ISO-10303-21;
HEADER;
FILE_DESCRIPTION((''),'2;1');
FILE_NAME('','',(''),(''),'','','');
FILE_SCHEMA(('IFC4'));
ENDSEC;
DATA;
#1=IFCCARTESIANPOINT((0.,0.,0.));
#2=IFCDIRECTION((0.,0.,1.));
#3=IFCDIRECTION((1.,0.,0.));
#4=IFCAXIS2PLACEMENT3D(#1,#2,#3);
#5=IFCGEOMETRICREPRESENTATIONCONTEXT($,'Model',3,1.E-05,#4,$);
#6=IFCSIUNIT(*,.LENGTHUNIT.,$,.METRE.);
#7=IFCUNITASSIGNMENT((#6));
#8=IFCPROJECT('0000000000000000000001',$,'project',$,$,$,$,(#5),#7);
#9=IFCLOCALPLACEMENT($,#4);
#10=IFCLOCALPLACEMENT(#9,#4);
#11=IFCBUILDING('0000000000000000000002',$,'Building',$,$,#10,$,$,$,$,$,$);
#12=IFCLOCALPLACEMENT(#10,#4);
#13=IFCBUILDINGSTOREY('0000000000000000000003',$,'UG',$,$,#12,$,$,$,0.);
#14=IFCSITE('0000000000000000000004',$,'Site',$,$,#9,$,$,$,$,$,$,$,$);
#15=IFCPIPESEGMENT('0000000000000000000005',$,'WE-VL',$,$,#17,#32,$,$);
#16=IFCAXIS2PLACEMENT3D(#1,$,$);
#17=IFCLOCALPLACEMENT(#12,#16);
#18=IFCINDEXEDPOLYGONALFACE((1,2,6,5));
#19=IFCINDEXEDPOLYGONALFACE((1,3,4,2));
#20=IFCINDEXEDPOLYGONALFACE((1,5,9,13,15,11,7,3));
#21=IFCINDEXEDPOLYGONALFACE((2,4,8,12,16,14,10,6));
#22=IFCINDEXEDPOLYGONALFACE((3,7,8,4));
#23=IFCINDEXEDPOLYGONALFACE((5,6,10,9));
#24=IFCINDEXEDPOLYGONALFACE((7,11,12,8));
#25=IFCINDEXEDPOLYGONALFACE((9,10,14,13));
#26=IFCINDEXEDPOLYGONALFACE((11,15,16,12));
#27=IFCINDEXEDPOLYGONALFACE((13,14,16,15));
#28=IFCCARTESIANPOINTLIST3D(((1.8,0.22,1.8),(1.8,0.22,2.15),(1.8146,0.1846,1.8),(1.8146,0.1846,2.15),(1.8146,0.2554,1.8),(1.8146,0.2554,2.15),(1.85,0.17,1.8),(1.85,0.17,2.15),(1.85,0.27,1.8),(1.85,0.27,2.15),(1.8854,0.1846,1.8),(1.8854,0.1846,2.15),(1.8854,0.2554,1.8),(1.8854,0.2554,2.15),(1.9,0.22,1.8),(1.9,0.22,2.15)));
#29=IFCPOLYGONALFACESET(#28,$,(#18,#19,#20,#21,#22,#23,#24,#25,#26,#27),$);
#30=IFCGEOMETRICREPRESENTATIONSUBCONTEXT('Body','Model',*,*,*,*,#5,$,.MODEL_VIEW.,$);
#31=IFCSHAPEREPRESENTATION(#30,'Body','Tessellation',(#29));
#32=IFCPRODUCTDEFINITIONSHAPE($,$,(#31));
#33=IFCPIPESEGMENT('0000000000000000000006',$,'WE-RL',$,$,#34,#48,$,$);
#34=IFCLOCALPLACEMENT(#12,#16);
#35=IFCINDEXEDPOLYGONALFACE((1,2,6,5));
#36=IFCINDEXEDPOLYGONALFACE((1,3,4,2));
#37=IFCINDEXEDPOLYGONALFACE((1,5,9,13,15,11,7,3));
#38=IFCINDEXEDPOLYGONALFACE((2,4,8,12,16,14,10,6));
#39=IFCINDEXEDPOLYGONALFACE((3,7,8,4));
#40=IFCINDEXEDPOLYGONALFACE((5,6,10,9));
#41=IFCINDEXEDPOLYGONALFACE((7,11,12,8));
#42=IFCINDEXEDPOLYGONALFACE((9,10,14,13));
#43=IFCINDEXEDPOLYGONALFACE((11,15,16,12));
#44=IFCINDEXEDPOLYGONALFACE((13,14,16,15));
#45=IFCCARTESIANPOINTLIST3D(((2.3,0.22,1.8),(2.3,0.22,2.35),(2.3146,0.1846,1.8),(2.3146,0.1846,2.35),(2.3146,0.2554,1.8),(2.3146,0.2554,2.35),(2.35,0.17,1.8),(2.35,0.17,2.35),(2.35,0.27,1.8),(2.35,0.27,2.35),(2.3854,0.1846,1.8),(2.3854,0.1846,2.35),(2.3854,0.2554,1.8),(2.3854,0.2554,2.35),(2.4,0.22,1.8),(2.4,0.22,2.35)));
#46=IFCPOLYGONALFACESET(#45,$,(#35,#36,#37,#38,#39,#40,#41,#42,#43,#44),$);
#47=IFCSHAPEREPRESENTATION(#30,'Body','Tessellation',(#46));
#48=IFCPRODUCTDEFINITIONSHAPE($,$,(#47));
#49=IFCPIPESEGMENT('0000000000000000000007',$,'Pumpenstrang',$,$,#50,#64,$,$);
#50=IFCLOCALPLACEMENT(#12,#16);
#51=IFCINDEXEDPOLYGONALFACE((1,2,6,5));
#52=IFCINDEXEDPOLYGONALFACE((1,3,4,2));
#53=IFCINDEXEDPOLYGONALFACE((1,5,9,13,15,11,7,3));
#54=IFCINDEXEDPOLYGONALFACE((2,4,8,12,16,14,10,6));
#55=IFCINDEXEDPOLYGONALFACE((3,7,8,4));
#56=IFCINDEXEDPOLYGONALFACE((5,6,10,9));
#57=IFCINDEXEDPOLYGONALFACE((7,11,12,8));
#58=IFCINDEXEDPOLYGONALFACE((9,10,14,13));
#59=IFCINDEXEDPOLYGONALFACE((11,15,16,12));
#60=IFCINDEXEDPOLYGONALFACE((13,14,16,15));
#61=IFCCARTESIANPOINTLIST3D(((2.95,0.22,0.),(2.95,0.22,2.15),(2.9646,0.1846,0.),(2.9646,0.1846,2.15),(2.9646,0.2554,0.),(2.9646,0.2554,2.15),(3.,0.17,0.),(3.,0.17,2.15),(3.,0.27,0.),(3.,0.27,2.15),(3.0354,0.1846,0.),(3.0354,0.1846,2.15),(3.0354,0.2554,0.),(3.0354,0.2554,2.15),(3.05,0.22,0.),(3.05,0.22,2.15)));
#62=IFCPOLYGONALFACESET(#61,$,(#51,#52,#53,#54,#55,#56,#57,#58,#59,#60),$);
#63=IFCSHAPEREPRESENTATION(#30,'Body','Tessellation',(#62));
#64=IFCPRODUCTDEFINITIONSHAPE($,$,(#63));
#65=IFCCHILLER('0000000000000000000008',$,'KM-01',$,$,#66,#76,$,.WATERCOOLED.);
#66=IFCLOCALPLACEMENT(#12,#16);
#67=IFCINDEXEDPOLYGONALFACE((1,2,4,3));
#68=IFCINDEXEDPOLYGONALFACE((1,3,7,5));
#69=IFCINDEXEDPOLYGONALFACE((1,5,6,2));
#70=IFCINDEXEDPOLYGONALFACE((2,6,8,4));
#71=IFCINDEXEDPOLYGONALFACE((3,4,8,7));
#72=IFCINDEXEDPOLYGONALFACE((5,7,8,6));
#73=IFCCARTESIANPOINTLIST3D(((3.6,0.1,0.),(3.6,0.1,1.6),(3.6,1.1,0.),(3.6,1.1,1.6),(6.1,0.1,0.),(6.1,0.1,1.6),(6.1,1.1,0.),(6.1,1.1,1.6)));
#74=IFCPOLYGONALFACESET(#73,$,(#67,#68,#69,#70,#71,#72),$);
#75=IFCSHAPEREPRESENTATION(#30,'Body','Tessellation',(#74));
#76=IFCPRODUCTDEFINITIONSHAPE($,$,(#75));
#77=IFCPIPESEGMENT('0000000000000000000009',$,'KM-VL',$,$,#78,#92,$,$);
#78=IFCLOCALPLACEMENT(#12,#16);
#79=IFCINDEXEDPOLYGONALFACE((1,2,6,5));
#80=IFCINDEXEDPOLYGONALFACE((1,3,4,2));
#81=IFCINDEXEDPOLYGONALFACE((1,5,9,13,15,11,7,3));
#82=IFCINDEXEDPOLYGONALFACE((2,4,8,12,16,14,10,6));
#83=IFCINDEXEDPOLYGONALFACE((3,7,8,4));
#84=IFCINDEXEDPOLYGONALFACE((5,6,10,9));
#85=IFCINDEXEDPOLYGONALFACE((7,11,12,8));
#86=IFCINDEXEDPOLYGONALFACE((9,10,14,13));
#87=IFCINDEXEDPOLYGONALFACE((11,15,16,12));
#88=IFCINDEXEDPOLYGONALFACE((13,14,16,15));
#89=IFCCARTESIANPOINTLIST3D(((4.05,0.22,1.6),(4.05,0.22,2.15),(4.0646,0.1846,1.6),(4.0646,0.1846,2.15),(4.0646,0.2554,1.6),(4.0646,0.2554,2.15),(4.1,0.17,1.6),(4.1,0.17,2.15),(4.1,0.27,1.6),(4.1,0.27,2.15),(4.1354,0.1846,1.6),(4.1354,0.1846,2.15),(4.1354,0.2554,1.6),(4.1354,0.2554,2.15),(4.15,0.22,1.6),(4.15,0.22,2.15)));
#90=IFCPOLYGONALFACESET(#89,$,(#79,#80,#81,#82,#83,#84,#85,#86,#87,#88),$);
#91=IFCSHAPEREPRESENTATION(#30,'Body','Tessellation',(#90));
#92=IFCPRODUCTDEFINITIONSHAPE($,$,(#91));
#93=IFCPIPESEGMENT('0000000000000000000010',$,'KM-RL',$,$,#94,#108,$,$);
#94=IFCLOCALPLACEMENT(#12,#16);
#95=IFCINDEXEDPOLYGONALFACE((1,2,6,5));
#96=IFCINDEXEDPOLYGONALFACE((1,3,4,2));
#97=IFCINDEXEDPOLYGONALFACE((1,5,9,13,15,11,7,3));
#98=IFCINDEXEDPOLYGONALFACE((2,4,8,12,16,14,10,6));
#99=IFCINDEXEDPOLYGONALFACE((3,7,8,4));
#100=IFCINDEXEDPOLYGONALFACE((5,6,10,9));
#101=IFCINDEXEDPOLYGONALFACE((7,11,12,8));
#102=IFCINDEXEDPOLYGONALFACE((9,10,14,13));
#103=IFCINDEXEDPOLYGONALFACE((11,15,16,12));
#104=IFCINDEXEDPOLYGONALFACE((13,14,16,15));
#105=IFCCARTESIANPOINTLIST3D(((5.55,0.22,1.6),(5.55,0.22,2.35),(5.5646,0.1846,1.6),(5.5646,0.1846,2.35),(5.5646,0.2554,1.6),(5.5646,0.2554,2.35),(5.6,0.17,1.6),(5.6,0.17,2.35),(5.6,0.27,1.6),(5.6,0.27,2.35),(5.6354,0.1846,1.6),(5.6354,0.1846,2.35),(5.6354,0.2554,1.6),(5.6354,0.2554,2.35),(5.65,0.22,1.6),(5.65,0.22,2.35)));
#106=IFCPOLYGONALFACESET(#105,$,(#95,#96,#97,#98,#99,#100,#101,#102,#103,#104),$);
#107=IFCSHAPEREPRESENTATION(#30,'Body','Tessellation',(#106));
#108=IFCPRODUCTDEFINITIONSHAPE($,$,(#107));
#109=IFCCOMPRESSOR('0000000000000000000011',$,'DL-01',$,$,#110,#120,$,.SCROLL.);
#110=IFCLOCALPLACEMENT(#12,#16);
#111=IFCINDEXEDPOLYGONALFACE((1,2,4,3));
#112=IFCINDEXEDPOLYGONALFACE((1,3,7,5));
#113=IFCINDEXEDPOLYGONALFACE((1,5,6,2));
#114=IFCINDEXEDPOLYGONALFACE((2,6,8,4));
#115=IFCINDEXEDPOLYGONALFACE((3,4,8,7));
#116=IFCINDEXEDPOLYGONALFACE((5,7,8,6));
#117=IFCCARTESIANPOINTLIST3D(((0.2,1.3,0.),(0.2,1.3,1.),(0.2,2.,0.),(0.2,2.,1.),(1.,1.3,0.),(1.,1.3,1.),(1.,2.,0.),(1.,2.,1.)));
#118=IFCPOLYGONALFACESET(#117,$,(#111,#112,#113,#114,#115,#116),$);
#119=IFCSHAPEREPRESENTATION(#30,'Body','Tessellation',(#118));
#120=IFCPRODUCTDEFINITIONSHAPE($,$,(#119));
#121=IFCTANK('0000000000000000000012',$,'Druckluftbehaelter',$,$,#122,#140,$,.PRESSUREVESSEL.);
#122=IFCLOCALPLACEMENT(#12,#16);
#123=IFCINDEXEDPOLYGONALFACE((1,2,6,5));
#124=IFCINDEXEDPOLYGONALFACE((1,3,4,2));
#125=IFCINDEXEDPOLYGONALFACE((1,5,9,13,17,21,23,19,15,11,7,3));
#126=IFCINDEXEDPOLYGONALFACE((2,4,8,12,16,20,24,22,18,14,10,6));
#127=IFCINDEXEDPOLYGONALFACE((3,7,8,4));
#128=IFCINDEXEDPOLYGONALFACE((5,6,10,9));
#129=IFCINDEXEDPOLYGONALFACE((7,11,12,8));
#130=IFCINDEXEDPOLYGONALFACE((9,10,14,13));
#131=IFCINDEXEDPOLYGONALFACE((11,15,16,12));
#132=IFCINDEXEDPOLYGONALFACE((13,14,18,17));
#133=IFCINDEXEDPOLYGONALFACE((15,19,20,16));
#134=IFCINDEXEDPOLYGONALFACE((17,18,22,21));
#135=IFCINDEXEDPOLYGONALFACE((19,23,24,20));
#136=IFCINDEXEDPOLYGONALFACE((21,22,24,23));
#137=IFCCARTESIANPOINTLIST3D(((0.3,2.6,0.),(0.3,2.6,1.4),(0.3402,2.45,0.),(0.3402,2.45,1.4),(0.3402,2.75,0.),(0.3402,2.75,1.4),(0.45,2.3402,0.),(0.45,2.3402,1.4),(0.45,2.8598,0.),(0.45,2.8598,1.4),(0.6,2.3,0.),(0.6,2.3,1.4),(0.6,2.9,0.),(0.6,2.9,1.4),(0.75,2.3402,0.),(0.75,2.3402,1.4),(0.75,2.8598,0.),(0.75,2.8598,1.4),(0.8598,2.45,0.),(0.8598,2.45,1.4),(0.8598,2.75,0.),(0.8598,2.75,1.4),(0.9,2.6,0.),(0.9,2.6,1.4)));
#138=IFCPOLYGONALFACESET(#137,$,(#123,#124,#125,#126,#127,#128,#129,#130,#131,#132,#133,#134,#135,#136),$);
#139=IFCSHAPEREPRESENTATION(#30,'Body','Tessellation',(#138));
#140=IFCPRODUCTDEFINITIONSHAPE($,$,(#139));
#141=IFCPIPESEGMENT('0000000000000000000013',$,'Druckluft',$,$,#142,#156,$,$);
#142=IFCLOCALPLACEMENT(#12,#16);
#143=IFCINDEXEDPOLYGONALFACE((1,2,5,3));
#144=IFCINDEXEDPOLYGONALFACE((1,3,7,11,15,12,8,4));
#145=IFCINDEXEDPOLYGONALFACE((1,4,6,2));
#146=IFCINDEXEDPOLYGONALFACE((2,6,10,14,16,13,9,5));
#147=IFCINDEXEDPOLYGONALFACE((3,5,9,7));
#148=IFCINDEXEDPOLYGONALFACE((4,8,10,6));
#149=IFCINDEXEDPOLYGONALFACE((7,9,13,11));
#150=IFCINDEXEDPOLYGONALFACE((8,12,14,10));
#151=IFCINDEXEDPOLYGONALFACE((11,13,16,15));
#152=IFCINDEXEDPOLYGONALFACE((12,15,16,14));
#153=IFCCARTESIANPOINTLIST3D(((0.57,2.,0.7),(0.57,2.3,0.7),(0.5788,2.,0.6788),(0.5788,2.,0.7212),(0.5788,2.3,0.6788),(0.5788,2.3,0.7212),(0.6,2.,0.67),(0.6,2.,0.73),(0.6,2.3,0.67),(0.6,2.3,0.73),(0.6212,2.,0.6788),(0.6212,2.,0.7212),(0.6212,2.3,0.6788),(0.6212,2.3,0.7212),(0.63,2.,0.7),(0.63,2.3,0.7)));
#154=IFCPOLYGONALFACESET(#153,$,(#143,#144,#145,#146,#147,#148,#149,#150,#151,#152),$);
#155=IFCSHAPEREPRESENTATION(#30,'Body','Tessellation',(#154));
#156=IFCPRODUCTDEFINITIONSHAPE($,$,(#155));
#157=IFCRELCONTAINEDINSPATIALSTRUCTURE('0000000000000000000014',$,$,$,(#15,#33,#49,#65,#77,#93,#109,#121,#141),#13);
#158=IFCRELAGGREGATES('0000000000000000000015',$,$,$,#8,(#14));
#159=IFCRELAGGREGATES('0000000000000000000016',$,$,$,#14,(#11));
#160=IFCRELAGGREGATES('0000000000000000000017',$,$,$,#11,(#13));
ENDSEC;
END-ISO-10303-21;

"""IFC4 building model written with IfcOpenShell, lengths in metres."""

from ifc_helpers import new_model, si_unit, frame, origin_with_axes, place, context, subcontext, project, spatial, polyline, outline, extrude, element, save


model = new_model("IFC4")

# Units and contexts
model_context = context("Model", 3, precision=1e-05, world=origin_with_axes())
body_context = subcontext(model_context, "Body", "Model", "MODEL_VIEW")
ifc_project = project(units=[si_unit("LENGTHUNIT", "METRE")], contexts=[model_context])

# Site, building, storey
site_placement = place(None, origin_with_axes())
site = spatial("IfcSite", under=ifc_project, at=site_placement, Name="Site")
building_placement = place(site_placement, origin_with_axes())
building = spatial("IfcBuilding", under=site, at=building_placement, Name="Building")
storey_placement = place(building_placement, origin_with_axes())
storey = spatial("IfcBuildingStorey", under=building, at=storey_placement, Name="UG", Elevation=0.0)

# Pipe segments
pipe_segment_1_placement = place(storey_placement, origin_with_axes())
element("IfcPipeSegment", 1, at=pipe_segment_1_placement, inside=storey, Name="WE-VL", context=body_context, shape_type="SweptSolid", body=[
    extrude(outline(polyline([(0.05, 0.0, 0.0), (0.0354, 0.0354, 0.0), (0.0, 0.05, 0.0), (-0.0354, 0.0354, 0.0), (-0.05, 0.0, 0.0), (-0.0354, -0.0354, 0.0), (0.0, -0.05, 0.0), (0.0354, -0.0354, 0.0), (0.05, 0.0, 0.0)])), frame((1.85, 0.22, 1.8), z_axis=(0.0, 0.0, 1.0), x_axis=(1.0, 0.0, 0.0)), (0.0, 0.0, 1.0), 0.35),
])
pipe_segment_2_placement = place(storey_placement, origin_with_axes())
element("IfcPipeSegment", 2, at=pipe_segment_2_placement, inside=storey, Name="WE-RL", context=body_context, shape_type="SweptSolid", body=[
    extrude(outline(polyline([(0.05, 0.0, 0.0), (0.0354, 0.0354, 0.0), (0.0, 0.05, 0.0), (-0.0354, 0.0354, 0.0), (-0.05, 0.0, 0.0), (-0.0354, -0.0354, 0.0), (0.0, -0.05, 0.0), (0.0354, -0.0354, 0.0), (0.05, 0.0, 0.0)])), frame((2.35, 0.22, 1.8), z_axis=(0.0, 0.0, 1.0), x_axis=(1.0, 0.0, 0.0)), (0.0, 0.0, 1.0), 0.55),
])
pipe_segment_3_placement = place(storey_placement, origin_with_axes())
element("IfcPipeSegment", 3, at=pipe_segment_3_placement, inside=storey, Name="Pumpenstrang", context=body_context, shape_type="SweptSolid", body=[
    extrude(outline(polyline([(0.05, 0.0, 0.0), (0.0354, 0.0354, 0.0), (0.0, 0.05, 0.0), (-0.0354, 0.0354, 0.0), (-0.05, 0.0, 0.0), (-0.0354, -0.0354, 0.0), (0.0, -0.05, 0.0), (0.0354, -0.0354, 0.0), (0.05, 0.0, 0.0)])), frame((3.0, 0.22, 0.0), z_axis=(0.0, 0.0, 1.0), x_axis=(1.0, 0.0, 0.0)), (0.0, 0.0, 1.0), 2.15),
])

# Chiller
chiller_placement = place(storey_placement, origin_with_axes())
element("IfcChiller", 4, at=chiller_placement, inside=storey, Name="KM-01", PredefinedType="WATERCOOLED", context=body_context, shape_type="SweptSolid", body=[
    extrude(outline(polyline([(3.6, 0.1, 0.0), (6.1, 0.1, 0.0), (6.1, 1.1, 0.0), (3.6, 1.1, 0.0), (3.6, 0.1, 0.0)])), origin_with_axes(), (0.0, 0.0, 1.0), 1.6),
])

# Pipe segments
pipe_segment_4_placement = place(storey_placement, origin_with_axes())
element("IfcPipeSegment", 5, at=pipe_segment_4_placement, inside=storey, Name="KM-VL", context=body_context, shape_type="SweptSolid", body=[
    extrude(outline(polyline([(0.05, 0.0, 0.0), (0.0354, 0.0354, 0.0), (0.0, 0.05, 0.0), (-0.0354, 0.0354, 0.0), (-0.05, 0.0, 0.0), (-0.0354, -0.0354, 0.0), (0.0, -0.05, 0.0), (0.0354, -0.0354, 0.0), (0.05, 0.0, 0.0)])), frame((4.1, 0.22, 1.6), z_axis=(0.0, 0.0, 1.0), x_axis=(1.0, 0.0, 0.0)), (0.0, 0.0, 1.0), 0.55),
])
pipe_segment_5_placement = place(storey_placement, origin_with_axes())
element("IfcPipeSegment", 6, at=pipe_segment_5_placement, inside=storey, Name="KM-RL", context=body_context, shape_type="SweptSolid", body=[
    extrude(outline(polyline([(0.05, 0.0, 0.0), (0.0354, 0.0354, 0.0), (0.0, 0.05, 0.0), (-0.0354, 0.0354, 0.0), (-0.05, 0.0, 0.0), (-0.0354, -0.0354, 0.0), (0.0, -0.05, 0.0), (0.0354, -0.0354, 0.0), (0.05, 0.0, 0.0)])), frame((5.6, 0.22, 1.6), z_axis=(0.0, 0.0, 1.0), x_axis=(1.0, 0.0, 0.0)), (0.0, 0.0, 1.0), 0.75),
])

# Compressor
compressor_placement = place(storey_placement, origin_with_axes())
element("IfcCompressor", 7, at=compressor_placement, inside=storey, Name="DL-01", PredefinedType="SCROLL", context=body_context, shape_type="SweptSolid", body=[
    extrude(outline(polyline([(0.2, 1.3, 0.0), (1.0, 1.3, 0.0), (1.0, 2.0, 0.0), (0.2, 2.0, 0.0), (0.2, 1.3, 0.0)])), origin_with_axes(), (0.0, 0.0, 1.0), 1.0),
])

# Tank
tank_1_placement = place(storey_placement, origin_with_axes())
element("IfcTank", 8, at=tank_1_placement, inside=storey, Name="Druckluftbehaelter", PredefinedType="PRESSUREVESSEL", context=body_context, shape_type="SweptSolid", body=[
    extrude(outline(polyline([(0.3, 0.0, 0.0), (0.2598, 0.15, 0.0), (0.15, 0.2598, 0.0), (0.0, 0.3, 0.0), (-0.15, 0.2598, 0.0), (-0.2598, 0.15, 0.0), (-0.3, 0.0, 0.0), (-0.2598, -0.15, 0.0), (-0.15, -0.2598, 0.0), (0.0, -0.3, 0.0), (0.15, -0.2598, 0.0), (0.2598, -0.15, 0.0), (0.3, 0.0, 0.0)])), frame((0.6, 2.6, 0.0), z_axis=(0.0, 0.0, 1.0), x_axis=(1.0, 0.0, 0.0)), (0.0, 0.0, 1.0), 1.4),
])

# Pipe segment
pipe_segment_6_placement = place(storey_placement, origin_with_axes())
element("IfcPipeSegment", 9, at=pipe_segment_6_placement, inside=storey, Name="Druckluft", context=body_context, shape_type="SweptSolid", body=[
    extrude(outline(polyline([(0.03, 0.0, 0.0), (0.0212, 0.0212, 0.0), (0.0, 0.03, 0.0), (-0.0212, 0.0212, 0.0), (-0.03, 0.0, 0.0), (-0.0212, -0.0212, 0.0), (0.0, -0.03, 0.0), (0.0212, -0.0212, 0.0), (0.03, 0.0, 0.0)])), frame((0.6, 2.0, 0.7), z_axis=(0.0, 1.0, 0.0), x_axis=(-1.0, 0.0, 0.0)), (0.0, 0.0, 1.0), 0.3),
])

save(model, "model.ifc")
